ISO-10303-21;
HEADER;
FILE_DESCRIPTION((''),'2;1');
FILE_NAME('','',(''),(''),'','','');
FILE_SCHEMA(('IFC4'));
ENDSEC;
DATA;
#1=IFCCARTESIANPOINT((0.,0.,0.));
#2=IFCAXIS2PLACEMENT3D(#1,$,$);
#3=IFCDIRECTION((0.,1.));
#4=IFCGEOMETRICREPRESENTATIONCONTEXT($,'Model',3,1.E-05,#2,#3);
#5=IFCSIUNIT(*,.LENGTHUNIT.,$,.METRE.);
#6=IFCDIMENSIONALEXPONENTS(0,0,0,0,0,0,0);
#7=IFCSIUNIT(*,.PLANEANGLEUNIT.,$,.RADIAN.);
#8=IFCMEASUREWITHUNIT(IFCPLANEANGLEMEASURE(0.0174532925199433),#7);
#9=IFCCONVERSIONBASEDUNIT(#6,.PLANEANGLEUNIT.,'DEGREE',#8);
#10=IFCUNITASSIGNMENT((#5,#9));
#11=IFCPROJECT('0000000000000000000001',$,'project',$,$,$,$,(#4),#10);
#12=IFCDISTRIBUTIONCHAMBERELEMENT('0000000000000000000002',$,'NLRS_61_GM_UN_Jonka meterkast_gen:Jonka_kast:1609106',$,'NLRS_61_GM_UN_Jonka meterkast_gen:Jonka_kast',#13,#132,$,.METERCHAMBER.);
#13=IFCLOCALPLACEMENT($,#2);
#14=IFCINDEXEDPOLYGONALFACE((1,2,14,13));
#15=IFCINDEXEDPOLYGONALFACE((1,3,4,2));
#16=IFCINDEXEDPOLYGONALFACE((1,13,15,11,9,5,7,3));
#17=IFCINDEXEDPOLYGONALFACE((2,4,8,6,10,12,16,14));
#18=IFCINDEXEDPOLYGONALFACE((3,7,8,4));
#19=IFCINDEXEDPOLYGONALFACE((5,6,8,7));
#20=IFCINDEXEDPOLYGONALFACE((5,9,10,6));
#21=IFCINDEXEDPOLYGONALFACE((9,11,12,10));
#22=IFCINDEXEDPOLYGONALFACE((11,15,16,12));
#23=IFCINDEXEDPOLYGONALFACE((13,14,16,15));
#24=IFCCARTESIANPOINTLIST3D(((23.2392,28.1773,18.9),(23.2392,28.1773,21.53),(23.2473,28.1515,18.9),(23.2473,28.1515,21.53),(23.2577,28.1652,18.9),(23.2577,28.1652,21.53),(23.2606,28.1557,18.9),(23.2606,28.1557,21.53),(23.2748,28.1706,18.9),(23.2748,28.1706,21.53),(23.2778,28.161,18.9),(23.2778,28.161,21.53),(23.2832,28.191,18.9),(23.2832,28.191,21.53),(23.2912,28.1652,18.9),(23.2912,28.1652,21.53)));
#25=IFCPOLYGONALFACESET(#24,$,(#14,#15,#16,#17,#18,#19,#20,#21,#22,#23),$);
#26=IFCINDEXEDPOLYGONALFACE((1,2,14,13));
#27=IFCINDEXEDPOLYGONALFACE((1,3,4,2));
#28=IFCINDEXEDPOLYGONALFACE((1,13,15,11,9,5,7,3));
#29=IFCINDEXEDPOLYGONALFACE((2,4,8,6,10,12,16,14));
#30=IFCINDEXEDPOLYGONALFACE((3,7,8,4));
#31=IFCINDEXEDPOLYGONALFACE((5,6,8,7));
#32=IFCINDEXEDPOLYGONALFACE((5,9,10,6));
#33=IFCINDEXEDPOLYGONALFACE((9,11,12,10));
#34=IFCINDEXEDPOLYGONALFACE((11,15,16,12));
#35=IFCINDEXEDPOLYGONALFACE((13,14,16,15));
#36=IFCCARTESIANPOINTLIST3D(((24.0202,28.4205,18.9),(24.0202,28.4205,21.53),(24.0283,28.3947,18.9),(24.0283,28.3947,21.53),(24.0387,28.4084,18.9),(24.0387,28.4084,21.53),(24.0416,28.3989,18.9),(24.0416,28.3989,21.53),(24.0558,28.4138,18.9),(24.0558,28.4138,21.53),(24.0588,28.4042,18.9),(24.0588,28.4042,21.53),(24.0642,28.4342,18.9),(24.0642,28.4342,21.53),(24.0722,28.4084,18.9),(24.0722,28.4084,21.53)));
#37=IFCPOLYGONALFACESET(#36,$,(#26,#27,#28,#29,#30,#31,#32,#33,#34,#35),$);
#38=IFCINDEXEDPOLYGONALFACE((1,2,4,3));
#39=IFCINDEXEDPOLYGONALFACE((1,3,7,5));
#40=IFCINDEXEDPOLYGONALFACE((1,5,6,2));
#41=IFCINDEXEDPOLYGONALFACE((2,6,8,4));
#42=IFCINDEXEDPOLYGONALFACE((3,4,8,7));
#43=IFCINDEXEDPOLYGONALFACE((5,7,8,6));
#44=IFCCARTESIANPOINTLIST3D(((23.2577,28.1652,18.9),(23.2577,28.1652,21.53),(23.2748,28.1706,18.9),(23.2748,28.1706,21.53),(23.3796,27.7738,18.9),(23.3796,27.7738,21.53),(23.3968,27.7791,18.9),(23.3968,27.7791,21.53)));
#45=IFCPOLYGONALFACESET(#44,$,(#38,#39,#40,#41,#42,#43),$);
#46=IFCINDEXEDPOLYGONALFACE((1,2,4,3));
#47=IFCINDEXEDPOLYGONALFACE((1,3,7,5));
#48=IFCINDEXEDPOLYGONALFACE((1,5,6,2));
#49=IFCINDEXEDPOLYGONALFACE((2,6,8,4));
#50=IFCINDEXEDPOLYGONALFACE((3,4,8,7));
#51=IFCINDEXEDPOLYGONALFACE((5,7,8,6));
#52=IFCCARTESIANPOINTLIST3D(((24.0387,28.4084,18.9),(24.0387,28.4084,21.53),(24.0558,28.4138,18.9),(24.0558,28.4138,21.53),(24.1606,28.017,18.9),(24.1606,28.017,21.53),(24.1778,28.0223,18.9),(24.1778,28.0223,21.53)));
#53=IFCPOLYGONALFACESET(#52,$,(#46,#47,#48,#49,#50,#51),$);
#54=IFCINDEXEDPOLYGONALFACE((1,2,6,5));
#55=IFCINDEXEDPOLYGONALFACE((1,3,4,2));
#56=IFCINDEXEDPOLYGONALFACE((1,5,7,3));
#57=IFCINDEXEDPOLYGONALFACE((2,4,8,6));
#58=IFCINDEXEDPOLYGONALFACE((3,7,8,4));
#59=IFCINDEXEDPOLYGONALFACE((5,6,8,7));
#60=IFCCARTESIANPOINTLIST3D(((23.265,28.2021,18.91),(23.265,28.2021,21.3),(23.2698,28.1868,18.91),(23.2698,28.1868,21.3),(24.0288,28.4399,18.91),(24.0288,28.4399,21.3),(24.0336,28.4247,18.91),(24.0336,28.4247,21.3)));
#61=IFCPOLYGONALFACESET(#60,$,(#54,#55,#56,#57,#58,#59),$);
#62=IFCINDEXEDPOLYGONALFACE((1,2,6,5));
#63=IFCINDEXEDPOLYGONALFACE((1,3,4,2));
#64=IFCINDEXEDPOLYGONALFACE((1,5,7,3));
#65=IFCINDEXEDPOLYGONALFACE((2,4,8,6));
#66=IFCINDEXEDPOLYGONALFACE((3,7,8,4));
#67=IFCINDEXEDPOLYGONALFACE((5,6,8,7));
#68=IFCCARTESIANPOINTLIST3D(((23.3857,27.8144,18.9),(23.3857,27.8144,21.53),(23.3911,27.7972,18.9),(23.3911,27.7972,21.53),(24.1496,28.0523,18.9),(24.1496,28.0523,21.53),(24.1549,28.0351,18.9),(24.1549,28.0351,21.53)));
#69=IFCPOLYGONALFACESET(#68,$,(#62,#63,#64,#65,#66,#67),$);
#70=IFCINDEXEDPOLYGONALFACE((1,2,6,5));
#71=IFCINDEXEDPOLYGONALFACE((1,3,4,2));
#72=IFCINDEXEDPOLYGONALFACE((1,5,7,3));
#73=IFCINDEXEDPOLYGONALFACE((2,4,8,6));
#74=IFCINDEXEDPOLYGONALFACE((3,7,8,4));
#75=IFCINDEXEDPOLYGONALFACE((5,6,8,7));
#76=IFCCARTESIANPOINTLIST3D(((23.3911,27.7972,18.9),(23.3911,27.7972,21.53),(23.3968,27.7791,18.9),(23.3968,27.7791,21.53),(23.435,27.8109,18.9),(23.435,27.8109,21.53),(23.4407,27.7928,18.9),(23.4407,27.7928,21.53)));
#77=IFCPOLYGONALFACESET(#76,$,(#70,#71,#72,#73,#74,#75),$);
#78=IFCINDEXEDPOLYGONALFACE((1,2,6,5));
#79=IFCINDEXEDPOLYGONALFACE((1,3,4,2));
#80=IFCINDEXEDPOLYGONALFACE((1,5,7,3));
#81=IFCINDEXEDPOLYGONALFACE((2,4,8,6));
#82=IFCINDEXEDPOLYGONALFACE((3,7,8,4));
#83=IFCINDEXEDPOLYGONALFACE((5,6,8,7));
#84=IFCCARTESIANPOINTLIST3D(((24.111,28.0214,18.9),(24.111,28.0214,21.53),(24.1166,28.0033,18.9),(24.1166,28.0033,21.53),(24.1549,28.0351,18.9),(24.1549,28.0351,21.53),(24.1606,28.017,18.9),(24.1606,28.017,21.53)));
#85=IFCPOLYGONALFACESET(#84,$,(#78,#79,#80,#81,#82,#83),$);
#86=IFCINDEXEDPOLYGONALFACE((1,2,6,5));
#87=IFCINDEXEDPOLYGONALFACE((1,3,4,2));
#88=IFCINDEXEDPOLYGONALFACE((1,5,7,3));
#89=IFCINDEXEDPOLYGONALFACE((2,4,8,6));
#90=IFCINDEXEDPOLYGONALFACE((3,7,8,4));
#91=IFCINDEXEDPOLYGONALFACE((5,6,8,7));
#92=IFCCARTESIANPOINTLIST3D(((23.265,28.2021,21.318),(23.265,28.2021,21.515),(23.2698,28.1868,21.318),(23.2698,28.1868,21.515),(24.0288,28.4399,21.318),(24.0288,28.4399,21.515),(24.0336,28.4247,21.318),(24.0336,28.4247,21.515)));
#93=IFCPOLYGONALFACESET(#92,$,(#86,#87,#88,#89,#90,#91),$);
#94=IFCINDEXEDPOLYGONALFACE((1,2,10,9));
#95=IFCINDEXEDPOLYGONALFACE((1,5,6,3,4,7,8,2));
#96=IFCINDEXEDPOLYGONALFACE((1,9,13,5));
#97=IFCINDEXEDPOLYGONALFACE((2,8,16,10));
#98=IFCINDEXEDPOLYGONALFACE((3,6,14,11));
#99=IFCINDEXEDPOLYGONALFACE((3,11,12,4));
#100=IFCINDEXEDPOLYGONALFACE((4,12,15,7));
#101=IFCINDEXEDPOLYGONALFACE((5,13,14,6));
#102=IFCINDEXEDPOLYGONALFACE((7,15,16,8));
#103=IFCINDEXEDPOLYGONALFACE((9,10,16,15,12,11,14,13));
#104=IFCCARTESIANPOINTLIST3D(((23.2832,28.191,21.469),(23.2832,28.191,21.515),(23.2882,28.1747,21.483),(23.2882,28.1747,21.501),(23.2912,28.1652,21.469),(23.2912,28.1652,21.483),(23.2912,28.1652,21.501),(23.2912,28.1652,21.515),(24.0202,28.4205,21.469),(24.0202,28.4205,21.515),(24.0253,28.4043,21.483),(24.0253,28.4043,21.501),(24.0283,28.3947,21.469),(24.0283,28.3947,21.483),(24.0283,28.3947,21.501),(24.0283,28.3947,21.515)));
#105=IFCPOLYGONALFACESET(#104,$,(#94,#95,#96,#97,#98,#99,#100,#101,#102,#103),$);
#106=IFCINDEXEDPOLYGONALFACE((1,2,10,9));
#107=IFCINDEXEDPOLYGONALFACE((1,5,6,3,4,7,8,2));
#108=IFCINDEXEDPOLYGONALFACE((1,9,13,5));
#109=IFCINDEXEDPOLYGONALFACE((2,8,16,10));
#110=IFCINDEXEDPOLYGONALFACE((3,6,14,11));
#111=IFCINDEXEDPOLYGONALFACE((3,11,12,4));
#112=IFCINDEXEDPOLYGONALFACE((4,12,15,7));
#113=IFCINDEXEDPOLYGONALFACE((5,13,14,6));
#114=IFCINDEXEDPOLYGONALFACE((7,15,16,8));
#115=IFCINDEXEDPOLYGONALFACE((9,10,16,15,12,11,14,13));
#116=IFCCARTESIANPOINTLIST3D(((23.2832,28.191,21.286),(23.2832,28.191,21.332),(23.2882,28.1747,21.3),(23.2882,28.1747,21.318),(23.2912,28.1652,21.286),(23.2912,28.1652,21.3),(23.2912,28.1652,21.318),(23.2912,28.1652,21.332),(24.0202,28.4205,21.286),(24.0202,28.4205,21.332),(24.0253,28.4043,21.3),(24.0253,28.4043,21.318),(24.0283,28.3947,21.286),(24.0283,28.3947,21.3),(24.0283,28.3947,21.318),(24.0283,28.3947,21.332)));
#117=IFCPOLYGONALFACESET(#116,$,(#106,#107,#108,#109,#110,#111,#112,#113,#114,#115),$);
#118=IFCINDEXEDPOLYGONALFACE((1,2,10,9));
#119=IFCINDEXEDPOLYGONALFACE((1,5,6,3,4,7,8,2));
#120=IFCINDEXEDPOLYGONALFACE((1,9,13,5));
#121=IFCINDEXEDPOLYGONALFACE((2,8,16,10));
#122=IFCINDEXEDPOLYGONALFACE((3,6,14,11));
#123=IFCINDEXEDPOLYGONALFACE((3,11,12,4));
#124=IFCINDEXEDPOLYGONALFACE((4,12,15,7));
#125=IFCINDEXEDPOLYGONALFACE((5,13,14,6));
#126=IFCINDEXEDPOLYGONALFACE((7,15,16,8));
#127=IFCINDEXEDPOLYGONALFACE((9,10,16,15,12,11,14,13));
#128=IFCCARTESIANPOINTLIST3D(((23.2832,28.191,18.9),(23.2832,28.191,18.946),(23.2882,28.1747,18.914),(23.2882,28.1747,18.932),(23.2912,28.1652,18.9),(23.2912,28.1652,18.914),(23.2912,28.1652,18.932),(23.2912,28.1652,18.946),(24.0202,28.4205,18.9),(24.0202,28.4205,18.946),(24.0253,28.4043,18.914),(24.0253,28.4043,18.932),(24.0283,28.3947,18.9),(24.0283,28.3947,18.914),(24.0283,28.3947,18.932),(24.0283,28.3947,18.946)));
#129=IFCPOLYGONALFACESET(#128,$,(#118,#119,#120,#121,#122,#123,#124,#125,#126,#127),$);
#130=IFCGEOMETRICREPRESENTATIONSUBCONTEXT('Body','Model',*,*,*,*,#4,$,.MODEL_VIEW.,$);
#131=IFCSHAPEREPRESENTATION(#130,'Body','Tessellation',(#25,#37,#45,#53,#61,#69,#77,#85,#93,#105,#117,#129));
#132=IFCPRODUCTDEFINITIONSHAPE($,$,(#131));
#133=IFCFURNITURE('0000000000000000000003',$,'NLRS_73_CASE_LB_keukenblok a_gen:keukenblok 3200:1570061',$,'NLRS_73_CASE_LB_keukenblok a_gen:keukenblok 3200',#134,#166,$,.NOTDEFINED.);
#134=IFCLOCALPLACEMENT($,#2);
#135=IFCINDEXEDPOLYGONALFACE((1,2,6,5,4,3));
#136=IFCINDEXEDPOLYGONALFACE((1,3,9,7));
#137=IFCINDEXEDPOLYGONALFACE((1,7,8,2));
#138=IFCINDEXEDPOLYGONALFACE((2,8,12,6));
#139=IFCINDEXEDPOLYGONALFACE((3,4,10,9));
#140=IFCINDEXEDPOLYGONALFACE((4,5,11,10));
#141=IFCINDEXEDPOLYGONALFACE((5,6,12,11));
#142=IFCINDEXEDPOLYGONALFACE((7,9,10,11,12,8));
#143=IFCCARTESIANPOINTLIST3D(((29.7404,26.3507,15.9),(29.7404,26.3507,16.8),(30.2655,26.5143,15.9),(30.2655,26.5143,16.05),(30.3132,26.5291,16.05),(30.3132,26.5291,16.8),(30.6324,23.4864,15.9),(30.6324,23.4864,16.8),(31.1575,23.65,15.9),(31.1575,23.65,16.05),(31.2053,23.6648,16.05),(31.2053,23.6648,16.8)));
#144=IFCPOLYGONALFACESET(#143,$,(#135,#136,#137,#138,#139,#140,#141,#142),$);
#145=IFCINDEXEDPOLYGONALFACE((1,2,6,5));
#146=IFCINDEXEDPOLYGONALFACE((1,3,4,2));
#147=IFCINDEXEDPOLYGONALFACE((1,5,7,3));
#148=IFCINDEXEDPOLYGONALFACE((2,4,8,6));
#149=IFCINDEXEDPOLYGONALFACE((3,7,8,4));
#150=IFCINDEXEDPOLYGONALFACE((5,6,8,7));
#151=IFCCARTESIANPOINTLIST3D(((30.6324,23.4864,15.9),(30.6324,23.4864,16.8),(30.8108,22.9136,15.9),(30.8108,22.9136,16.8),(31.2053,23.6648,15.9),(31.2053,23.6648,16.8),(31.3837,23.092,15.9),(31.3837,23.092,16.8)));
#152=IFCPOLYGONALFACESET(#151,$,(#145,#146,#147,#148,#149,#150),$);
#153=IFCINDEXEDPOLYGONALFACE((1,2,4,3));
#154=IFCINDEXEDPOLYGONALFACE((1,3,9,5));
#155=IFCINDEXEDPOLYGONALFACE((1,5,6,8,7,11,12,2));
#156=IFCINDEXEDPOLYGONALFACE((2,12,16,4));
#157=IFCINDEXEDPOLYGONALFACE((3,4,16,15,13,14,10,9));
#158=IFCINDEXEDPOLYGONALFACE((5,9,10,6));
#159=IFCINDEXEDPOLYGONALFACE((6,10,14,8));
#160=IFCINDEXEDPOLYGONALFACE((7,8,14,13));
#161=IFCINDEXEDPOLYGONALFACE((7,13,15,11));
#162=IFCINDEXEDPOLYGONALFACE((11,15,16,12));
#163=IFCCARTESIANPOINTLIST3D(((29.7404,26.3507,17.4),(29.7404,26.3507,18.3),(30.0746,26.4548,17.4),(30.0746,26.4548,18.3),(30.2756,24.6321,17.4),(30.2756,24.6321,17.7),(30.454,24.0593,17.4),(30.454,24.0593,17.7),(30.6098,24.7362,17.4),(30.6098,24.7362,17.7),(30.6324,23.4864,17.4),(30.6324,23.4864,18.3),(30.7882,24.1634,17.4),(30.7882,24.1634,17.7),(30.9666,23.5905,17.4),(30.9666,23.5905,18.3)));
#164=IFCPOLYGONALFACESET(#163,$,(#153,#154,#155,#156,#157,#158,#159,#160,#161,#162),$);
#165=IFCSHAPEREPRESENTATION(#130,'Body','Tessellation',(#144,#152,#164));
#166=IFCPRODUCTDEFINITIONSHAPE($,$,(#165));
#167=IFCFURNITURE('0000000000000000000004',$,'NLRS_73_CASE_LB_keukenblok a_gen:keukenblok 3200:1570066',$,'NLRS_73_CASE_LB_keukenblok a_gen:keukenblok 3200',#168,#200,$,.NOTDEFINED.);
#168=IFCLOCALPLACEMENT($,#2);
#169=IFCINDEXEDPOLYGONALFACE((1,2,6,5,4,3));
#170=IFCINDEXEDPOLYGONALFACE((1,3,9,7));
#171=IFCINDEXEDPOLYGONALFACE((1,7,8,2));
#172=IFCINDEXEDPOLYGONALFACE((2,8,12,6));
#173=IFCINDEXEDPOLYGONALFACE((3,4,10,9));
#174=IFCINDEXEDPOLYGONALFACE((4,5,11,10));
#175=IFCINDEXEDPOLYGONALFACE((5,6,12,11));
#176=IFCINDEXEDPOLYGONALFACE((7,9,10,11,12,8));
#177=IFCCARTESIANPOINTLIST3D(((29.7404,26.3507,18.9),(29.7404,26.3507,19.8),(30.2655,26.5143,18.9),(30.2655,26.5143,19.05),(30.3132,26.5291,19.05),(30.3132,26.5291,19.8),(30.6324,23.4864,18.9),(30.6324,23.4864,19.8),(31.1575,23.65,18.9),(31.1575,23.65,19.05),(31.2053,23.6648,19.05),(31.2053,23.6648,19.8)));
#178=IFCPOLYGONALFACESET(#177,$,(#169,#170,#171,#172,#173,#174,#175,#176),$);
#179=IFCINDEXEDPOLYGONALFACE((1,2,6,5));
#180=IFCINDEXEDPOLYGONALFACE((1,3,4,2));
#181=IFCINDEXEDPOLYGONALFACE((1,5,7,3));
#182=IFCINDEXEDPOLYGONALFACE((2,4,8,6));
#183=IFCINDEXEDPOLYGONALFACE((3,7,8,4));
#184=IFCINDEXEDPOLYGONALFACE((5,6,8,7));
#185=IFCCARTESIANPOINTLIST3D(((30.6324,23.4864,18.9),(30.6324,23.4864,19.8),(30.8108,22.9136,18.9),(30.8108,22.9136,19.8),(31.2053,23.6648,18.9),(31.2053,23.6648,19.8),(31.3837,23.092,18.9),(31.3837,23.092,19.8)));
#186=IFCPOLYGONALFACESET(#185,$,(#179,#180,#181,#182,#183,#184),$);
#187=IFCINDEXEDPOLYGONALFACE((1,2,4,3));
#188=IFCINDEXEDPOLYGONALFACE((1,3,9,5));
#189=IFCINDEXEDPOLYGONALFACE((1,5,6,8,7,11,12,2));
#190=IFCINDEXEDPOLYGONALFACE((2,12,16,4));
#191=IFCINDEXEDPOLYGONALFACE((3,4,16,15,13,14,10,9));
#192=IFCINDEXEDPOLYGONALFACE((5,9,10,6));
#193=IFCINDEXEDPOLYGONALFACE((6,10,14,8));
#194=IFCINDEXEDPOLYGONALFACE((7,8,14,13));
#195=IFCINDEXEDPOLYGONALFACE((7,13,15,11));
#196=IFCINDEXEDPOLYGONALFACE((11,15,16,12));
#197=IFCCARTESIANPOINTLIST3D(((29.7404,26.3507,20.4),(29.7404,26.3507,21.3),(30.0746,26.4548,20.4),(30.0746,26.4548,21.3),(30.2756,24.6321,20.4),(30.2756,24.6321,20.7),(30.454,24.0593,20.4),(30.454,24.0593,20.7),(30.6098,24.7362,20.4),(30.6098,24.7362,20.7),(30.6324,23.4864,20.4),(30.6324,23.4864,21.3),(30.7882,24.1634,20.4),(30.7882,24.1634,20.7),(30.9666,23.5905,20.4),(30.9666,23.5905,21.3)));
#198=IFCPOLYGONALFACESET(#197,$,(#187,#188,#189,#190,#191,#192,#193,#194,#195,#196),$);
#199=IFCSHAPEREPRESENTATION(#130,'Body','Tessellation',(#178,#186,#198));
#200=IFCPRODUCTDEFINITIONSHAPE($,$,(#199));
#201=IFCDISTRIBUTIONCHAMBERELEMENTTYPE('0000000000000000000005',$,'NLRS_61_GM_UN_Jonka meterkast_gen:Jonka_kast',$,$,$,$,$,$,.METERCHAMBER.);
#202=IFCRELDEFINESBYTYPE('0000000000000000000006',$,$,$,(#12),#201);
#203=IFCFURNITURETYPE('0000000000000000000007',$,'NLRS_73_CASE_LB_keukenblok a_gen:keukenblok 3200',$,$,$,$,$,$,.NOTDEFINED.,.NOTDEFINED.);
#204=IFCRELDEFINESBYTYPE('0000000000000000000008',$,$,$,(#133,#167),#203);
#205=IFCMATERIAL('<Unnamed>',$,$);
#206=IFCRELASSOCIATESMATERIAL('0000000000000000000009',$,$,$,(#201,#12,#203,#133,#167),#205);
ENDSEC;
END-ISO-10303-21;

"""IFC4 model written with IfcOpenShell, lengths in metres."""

from ifc_helpers import new_model, entity, si_unit, converted_unit, direction, frame, origin, place, context, subcontext, project, indexed_curve, outline, extrude, source, transform, mapped, material, type_object, type_shapes, element, save


model = new_model("IFC4")

# Units and contexts
model_context = context("Model", 3, precision=1e-05, world=origin(), true_north=direction((0.0, 1.0)))
body_context = subcontext(model_context, "Body", "Model", "MODEL_VIEW")
ifc_project = project(units=[si_unit("LENGTHUNIT", "METRE"), converted_unit("PLANEANGLEUNIT", "DEGREE", entity("IfcPlaneAngleMeasure", 0.0174532925199433), si_unit("PLANEANGLEUNIT", "RADIAN"), dimensions=[0, 0, 0, 0, 0, 0, 0])], contexts=[model_context])

# Shared definitions
ifc_material = material(Name="<Unnamed>")
distribution_chamber_element_type = type_object("IfcDistributionChamberElementType", Name="NLRS_61_GM_UN_Jonka meterkast_gen:Jonka_kast", PredefinedType="METERCHAMBER", material=ifc_material)
placement_1 = place(None, frame((13.1348, 11.9886, 0.0), z_axis=(0.0, 0.0, 1.0), x_axis=(0.954771, 0.297342, 0.0)))
placement_2 = place(placement_1, origin())
placement_3 = place(placement_2, frame((0.0, 0.0, 15.9)))
placement_4 = place(placement_2, frame((0.0, 0.0, 18.9)))

# Distribution chamber element
shared_shape_1 = source(origin(), body_context, "Body", "SweptSolid", [
    extrude(outline(indexed_curve([(-0.023, -0.0093), (-0.009, -0.0093), (-0.009, 0.0007), (0.009, 0.0007), (0.009, -0.0093), (0.023, -0.0093), (0.023, 0.0178), (-0.023, 0.0178), (-0.023, -0.0093)], self_intersect=False)), frame((-0.409, 0.4092, 0.0)), (0.0, 0.0, 1.0), 2.63),
    extrude(outline(indexed_curve([(-0.023, -0.0093), (-0.009, -0.0093), (-0.009, 0.0007), (0.009, 0.0007), (0.009, -0.0093), (0.023, -0.0093), (0.023, 0.0178), (-0.023, 0.0178), (-0.023, -0.0093)], self_intersect=False)), frame((0.409, 0.4092, 0.0)), (0.0, 0.0, 1.0), 2.63),
    extrude(outline(indexed_curve([(-0.009, -0.205), (0.009, -0.205), (0.009, 0.205), (-0.009, 0.205), (-0.009, -0.205)], self_intersect=False)), frame((-0.409, 0.205, 0.0)), (0.0, 0.0, 1.0), 2.63),
    extrude(outline(indexed_curve([(-0.009, -0.205), (0.009, -0.205), (0.009, 0.205), (-0.009, 0.205), (-0.009, -0.205)], self_intersect=False)), frame((0.409, 0.205, 0.0)), (0.0, 0.0, 1.0), 2.63),
    extrude(outline(indexed_curve([(-0.008, -0.4), (0.008, -0.4), (0.008, 0.4), (-0.008, 0.4), (-0.008, -0.4)], self_intersect=False)), frame((0.0, 0.435, 0.01), z_axis=(0.0, 0.0, 1.0), x_axis=(0.0, 1.0, 0.0)), (0.0, 0.0, 1.0), 2.39),
    extrude(outline(indexed_curve([(-0.009, -0.4), (0.009, -0.4), (0.009, 0.4), (-0.009, 0.4), (-0.009, -0.4)], self_intersect=False)), frame((0.0, 0.028, 0.0), z_axis=(0.0, 0.0, 1.0), x_axis=(0.0, 1.0, 0.0)), (0.0, 0.0, 1.0), 2.63),
    extrude(outline(indexed_curve([(-0.0095, -0.023), (0.0095, -0.023), (0.0095, 0.023), (-0.0095, 0.023), (-0.0095, -0.023)], self_intersect=False)), frame((-0.377, 0.0095, 0.0), z_axis=(0.0, 0.0, 1.0), x_axis=(0.0, 1.0, 0.0)), (0.0, 0.0, 1.0), 2.63),
    extrude(outline(indexed_curve([(-0.0095, -0.023), (0.0095, -0.023), (0.0095, 0.023), (-0.0095, 0.023), (-0.0095, -0.023)], self_intersect=False)), frame((0.377, 0.0095, 0.0), z_axis=(0.0, 0.0, 1.0), x_axis=(0.0, 1.0, 0.0)), (0.0, 0.0, 1.0), 2.63),
    extrude(outline(indexed_curve([(-0.008, -0.4), (0.008, -0.4), (0.008, 0.4), (-0.008, 0.4), (-0.008, -0.4)], self_intersect=False)), frame((0.0, 0.435, 2.418), z_axis=(0.0, 0.0, 1.0), x_axis=(0.0, 1.0, 0.0)), (0.0, 0.0, 1.0), 0.197),
    extrude(outline(indexed_curve([(-0.0178, -0.023), (0.0093, -0.023), (0.0093, -0.009), (-0.0007, -0.009), (-0.0007, 0.009), (0.0093, 0.009), (0.0093, 0.023), (-0.0178, 0.023), (-0.0178, -0.023)], self_intersect=False)), frame((-0.386, 0.4092, 2.592), z_axis=(1.0, 0.0, 0.0), x_axis=(0.0, -1.0, 0.0)), (0.0, 0.0, 1.0), 0.772),
    extrude(outline(indexed_curve([(-0.0178, -0.023), (0.0093, -0.023), (0.0093, -0.009), (-0.0007, -0.009), (-0.0007, 0.009), (0.0093, 0.009), (0.0093, 0.023), (-0.0178, 0.023), (-0.0178, -0.023)], self_intersect=False)), frame((-0.386, 0.4092, 2.409), z_axis=(1.0, 0.0, 0.0), x_axis=(0.0, -1.0, 0.0)), (0.0, 0.0, 1.0), 0.772),
    extrude(outline(indexed_curve([(-0.0178, -0.023), (0.0093, -0.023), (0.0093, -0.009), (-0.0007, -0.009), (-0.0007, 0.009), (0.0093, 0.009), (0.0093, 0.023), (-0.0178, 0.023), (-0.0178, -0.023)], self_intersect=False)), frame((-0.386, 0.4092, 0.023), z_axis=(1.0, 0.0, 0.0), x_axis=(0.0, -1.0, 0.0)), (0.0, 0.0, 1.0), 0.772),
])
placement_5 = place(placement_4, origin())
distribution_chamber_element_1_placement = place(placement_5, frame((14.893, 12.025, 0.0)))
element("IfcDistributionChamberElement", 1, at=distribution_chamber_element_1_placement, type_object=distribution_chamber_element_type, material=ifc_material, Name="NLRS_61_GM_UN_Jonka meterkast_gen:Jonka_kast:1609106", ObjectType="NLRS_61_GM_UN_Jonka meterkast_gen:Jonka_kast", PredefinedType="METERCHAMBER", context=body_context, shape_type="MappedRepresentation", body=[
    mapped(shared_shape_1, transform((0.0, 0.0, 0.0), scale=1.0)),
])

# Furniture
furniture_type = type_object("IfcFurnitureType", Name="NLRS_73_CASE_LB_keukenblok a_gen:keukenblok 3200", AssemblyPlace="NOTDEFINED", PredefinedType="NOTDEFINED", material=ifc_material)
shared_shape_2 = source(origin(), body_context, "Body", "SweptSolid", [
    extrude(outline(indexed_curve([(-0.35, 0.1667), (-0.35, -0.3833), (0.55, -0.3833), (0.55, 0.2167), (-0.2, 0.2167), (-0.2, 0.1667), (-0.35, 0.1667)], self_intersect=False)), frame((0.0, 0.3833, 0.35), z_axis=(-1.0, 0.0, 0.0), x_axis=(0.0, 0.0, 1.0)), (0.0, 0.0, -1.0), 3.0),
    extrude(outline(indexed_curve([(-0.3, -0.3), (0.3, -0.3), (0.3, 0.3), (-0.3, 0.3), (-0.3, -0.3)], self_intersect=False)), frame((3.3, 0.3, 0.0), z_axis=(0.0, 0.0, 1.0), x_axis=(0.0, 1.0, 0.0)), (0.0, 0.0, 1.0), 0.9),
    extrude(outline(indexed_curve([(-1.2, -0.3), (-0.6, -0.3), (-0.6, 0.0), (0.0, 0.0), (0.0, -0.3), (1.8, -0.3), (1.8, 0.6), (-1.2, 0.6), (-1.2, -0.3)], self_intersect=False)), frame((1.8, 0.0, 1.8), z_axis=(0.0, 1.0, 0.0), x_axis=(-1.0, 0.0, 0.0)), (0.0, 0.0, 1.0), 0.35),
])
type_shapes(furniture_type, [shared_shape_2])
placement_6 = place(placement_3, origin())
furniture_1_placement = place(placement_6, frame((20.125, 8.775, 0.0), z_axis=(0.0, 0.0, 1.0), x_axis=(0.0, -1.0, 0.0)))
element("IfcFurniture", 2, at=furniture_1_placement, type_object=furniture_type, material=ifc_material, Name="NLRS_73_CASE_LB_keukenblok a_gen:keukenblok 3200:1570061", ObjectType="NLRS_73_CASE_LB_keukenblok a_gen:keukenblok 3200", PredefinedType="NOTDEFINED", context=body_context, shape_type="MappedRepresentation", body=[
    mapped(shared_shape_2, transform((0.0, 0.0, 0.0), scale=1.0)),
])
placement_7 = place(placement_4, origin())
furniture_2_placement = place(placement_7, frame((20.125, 8.775, 0.0), z_axis=(0.0, 0.0, 1.0), x_axis=(0.0, -1.0, 0.0)))
element("IfcFurniture", 3, at=furniture_2_placement, type_object=furniture_type, material=ifc_material, Name="NLRS_73_CASE_LB_keukenblok a_gen:keukenblok 3200:1570066", ObjectType="NLRS_73_CASE_LB_keukenblok a_gen:keukenblok 3200", PredefinedType="NOTDEFINED", context=body_context, shape_type="MappedRepresentation", body=[
    mapped(shared_shape_2, transform((0.0, 0.0, 0.0), scale=1.0)),
])

save(model, "model.ifc")
